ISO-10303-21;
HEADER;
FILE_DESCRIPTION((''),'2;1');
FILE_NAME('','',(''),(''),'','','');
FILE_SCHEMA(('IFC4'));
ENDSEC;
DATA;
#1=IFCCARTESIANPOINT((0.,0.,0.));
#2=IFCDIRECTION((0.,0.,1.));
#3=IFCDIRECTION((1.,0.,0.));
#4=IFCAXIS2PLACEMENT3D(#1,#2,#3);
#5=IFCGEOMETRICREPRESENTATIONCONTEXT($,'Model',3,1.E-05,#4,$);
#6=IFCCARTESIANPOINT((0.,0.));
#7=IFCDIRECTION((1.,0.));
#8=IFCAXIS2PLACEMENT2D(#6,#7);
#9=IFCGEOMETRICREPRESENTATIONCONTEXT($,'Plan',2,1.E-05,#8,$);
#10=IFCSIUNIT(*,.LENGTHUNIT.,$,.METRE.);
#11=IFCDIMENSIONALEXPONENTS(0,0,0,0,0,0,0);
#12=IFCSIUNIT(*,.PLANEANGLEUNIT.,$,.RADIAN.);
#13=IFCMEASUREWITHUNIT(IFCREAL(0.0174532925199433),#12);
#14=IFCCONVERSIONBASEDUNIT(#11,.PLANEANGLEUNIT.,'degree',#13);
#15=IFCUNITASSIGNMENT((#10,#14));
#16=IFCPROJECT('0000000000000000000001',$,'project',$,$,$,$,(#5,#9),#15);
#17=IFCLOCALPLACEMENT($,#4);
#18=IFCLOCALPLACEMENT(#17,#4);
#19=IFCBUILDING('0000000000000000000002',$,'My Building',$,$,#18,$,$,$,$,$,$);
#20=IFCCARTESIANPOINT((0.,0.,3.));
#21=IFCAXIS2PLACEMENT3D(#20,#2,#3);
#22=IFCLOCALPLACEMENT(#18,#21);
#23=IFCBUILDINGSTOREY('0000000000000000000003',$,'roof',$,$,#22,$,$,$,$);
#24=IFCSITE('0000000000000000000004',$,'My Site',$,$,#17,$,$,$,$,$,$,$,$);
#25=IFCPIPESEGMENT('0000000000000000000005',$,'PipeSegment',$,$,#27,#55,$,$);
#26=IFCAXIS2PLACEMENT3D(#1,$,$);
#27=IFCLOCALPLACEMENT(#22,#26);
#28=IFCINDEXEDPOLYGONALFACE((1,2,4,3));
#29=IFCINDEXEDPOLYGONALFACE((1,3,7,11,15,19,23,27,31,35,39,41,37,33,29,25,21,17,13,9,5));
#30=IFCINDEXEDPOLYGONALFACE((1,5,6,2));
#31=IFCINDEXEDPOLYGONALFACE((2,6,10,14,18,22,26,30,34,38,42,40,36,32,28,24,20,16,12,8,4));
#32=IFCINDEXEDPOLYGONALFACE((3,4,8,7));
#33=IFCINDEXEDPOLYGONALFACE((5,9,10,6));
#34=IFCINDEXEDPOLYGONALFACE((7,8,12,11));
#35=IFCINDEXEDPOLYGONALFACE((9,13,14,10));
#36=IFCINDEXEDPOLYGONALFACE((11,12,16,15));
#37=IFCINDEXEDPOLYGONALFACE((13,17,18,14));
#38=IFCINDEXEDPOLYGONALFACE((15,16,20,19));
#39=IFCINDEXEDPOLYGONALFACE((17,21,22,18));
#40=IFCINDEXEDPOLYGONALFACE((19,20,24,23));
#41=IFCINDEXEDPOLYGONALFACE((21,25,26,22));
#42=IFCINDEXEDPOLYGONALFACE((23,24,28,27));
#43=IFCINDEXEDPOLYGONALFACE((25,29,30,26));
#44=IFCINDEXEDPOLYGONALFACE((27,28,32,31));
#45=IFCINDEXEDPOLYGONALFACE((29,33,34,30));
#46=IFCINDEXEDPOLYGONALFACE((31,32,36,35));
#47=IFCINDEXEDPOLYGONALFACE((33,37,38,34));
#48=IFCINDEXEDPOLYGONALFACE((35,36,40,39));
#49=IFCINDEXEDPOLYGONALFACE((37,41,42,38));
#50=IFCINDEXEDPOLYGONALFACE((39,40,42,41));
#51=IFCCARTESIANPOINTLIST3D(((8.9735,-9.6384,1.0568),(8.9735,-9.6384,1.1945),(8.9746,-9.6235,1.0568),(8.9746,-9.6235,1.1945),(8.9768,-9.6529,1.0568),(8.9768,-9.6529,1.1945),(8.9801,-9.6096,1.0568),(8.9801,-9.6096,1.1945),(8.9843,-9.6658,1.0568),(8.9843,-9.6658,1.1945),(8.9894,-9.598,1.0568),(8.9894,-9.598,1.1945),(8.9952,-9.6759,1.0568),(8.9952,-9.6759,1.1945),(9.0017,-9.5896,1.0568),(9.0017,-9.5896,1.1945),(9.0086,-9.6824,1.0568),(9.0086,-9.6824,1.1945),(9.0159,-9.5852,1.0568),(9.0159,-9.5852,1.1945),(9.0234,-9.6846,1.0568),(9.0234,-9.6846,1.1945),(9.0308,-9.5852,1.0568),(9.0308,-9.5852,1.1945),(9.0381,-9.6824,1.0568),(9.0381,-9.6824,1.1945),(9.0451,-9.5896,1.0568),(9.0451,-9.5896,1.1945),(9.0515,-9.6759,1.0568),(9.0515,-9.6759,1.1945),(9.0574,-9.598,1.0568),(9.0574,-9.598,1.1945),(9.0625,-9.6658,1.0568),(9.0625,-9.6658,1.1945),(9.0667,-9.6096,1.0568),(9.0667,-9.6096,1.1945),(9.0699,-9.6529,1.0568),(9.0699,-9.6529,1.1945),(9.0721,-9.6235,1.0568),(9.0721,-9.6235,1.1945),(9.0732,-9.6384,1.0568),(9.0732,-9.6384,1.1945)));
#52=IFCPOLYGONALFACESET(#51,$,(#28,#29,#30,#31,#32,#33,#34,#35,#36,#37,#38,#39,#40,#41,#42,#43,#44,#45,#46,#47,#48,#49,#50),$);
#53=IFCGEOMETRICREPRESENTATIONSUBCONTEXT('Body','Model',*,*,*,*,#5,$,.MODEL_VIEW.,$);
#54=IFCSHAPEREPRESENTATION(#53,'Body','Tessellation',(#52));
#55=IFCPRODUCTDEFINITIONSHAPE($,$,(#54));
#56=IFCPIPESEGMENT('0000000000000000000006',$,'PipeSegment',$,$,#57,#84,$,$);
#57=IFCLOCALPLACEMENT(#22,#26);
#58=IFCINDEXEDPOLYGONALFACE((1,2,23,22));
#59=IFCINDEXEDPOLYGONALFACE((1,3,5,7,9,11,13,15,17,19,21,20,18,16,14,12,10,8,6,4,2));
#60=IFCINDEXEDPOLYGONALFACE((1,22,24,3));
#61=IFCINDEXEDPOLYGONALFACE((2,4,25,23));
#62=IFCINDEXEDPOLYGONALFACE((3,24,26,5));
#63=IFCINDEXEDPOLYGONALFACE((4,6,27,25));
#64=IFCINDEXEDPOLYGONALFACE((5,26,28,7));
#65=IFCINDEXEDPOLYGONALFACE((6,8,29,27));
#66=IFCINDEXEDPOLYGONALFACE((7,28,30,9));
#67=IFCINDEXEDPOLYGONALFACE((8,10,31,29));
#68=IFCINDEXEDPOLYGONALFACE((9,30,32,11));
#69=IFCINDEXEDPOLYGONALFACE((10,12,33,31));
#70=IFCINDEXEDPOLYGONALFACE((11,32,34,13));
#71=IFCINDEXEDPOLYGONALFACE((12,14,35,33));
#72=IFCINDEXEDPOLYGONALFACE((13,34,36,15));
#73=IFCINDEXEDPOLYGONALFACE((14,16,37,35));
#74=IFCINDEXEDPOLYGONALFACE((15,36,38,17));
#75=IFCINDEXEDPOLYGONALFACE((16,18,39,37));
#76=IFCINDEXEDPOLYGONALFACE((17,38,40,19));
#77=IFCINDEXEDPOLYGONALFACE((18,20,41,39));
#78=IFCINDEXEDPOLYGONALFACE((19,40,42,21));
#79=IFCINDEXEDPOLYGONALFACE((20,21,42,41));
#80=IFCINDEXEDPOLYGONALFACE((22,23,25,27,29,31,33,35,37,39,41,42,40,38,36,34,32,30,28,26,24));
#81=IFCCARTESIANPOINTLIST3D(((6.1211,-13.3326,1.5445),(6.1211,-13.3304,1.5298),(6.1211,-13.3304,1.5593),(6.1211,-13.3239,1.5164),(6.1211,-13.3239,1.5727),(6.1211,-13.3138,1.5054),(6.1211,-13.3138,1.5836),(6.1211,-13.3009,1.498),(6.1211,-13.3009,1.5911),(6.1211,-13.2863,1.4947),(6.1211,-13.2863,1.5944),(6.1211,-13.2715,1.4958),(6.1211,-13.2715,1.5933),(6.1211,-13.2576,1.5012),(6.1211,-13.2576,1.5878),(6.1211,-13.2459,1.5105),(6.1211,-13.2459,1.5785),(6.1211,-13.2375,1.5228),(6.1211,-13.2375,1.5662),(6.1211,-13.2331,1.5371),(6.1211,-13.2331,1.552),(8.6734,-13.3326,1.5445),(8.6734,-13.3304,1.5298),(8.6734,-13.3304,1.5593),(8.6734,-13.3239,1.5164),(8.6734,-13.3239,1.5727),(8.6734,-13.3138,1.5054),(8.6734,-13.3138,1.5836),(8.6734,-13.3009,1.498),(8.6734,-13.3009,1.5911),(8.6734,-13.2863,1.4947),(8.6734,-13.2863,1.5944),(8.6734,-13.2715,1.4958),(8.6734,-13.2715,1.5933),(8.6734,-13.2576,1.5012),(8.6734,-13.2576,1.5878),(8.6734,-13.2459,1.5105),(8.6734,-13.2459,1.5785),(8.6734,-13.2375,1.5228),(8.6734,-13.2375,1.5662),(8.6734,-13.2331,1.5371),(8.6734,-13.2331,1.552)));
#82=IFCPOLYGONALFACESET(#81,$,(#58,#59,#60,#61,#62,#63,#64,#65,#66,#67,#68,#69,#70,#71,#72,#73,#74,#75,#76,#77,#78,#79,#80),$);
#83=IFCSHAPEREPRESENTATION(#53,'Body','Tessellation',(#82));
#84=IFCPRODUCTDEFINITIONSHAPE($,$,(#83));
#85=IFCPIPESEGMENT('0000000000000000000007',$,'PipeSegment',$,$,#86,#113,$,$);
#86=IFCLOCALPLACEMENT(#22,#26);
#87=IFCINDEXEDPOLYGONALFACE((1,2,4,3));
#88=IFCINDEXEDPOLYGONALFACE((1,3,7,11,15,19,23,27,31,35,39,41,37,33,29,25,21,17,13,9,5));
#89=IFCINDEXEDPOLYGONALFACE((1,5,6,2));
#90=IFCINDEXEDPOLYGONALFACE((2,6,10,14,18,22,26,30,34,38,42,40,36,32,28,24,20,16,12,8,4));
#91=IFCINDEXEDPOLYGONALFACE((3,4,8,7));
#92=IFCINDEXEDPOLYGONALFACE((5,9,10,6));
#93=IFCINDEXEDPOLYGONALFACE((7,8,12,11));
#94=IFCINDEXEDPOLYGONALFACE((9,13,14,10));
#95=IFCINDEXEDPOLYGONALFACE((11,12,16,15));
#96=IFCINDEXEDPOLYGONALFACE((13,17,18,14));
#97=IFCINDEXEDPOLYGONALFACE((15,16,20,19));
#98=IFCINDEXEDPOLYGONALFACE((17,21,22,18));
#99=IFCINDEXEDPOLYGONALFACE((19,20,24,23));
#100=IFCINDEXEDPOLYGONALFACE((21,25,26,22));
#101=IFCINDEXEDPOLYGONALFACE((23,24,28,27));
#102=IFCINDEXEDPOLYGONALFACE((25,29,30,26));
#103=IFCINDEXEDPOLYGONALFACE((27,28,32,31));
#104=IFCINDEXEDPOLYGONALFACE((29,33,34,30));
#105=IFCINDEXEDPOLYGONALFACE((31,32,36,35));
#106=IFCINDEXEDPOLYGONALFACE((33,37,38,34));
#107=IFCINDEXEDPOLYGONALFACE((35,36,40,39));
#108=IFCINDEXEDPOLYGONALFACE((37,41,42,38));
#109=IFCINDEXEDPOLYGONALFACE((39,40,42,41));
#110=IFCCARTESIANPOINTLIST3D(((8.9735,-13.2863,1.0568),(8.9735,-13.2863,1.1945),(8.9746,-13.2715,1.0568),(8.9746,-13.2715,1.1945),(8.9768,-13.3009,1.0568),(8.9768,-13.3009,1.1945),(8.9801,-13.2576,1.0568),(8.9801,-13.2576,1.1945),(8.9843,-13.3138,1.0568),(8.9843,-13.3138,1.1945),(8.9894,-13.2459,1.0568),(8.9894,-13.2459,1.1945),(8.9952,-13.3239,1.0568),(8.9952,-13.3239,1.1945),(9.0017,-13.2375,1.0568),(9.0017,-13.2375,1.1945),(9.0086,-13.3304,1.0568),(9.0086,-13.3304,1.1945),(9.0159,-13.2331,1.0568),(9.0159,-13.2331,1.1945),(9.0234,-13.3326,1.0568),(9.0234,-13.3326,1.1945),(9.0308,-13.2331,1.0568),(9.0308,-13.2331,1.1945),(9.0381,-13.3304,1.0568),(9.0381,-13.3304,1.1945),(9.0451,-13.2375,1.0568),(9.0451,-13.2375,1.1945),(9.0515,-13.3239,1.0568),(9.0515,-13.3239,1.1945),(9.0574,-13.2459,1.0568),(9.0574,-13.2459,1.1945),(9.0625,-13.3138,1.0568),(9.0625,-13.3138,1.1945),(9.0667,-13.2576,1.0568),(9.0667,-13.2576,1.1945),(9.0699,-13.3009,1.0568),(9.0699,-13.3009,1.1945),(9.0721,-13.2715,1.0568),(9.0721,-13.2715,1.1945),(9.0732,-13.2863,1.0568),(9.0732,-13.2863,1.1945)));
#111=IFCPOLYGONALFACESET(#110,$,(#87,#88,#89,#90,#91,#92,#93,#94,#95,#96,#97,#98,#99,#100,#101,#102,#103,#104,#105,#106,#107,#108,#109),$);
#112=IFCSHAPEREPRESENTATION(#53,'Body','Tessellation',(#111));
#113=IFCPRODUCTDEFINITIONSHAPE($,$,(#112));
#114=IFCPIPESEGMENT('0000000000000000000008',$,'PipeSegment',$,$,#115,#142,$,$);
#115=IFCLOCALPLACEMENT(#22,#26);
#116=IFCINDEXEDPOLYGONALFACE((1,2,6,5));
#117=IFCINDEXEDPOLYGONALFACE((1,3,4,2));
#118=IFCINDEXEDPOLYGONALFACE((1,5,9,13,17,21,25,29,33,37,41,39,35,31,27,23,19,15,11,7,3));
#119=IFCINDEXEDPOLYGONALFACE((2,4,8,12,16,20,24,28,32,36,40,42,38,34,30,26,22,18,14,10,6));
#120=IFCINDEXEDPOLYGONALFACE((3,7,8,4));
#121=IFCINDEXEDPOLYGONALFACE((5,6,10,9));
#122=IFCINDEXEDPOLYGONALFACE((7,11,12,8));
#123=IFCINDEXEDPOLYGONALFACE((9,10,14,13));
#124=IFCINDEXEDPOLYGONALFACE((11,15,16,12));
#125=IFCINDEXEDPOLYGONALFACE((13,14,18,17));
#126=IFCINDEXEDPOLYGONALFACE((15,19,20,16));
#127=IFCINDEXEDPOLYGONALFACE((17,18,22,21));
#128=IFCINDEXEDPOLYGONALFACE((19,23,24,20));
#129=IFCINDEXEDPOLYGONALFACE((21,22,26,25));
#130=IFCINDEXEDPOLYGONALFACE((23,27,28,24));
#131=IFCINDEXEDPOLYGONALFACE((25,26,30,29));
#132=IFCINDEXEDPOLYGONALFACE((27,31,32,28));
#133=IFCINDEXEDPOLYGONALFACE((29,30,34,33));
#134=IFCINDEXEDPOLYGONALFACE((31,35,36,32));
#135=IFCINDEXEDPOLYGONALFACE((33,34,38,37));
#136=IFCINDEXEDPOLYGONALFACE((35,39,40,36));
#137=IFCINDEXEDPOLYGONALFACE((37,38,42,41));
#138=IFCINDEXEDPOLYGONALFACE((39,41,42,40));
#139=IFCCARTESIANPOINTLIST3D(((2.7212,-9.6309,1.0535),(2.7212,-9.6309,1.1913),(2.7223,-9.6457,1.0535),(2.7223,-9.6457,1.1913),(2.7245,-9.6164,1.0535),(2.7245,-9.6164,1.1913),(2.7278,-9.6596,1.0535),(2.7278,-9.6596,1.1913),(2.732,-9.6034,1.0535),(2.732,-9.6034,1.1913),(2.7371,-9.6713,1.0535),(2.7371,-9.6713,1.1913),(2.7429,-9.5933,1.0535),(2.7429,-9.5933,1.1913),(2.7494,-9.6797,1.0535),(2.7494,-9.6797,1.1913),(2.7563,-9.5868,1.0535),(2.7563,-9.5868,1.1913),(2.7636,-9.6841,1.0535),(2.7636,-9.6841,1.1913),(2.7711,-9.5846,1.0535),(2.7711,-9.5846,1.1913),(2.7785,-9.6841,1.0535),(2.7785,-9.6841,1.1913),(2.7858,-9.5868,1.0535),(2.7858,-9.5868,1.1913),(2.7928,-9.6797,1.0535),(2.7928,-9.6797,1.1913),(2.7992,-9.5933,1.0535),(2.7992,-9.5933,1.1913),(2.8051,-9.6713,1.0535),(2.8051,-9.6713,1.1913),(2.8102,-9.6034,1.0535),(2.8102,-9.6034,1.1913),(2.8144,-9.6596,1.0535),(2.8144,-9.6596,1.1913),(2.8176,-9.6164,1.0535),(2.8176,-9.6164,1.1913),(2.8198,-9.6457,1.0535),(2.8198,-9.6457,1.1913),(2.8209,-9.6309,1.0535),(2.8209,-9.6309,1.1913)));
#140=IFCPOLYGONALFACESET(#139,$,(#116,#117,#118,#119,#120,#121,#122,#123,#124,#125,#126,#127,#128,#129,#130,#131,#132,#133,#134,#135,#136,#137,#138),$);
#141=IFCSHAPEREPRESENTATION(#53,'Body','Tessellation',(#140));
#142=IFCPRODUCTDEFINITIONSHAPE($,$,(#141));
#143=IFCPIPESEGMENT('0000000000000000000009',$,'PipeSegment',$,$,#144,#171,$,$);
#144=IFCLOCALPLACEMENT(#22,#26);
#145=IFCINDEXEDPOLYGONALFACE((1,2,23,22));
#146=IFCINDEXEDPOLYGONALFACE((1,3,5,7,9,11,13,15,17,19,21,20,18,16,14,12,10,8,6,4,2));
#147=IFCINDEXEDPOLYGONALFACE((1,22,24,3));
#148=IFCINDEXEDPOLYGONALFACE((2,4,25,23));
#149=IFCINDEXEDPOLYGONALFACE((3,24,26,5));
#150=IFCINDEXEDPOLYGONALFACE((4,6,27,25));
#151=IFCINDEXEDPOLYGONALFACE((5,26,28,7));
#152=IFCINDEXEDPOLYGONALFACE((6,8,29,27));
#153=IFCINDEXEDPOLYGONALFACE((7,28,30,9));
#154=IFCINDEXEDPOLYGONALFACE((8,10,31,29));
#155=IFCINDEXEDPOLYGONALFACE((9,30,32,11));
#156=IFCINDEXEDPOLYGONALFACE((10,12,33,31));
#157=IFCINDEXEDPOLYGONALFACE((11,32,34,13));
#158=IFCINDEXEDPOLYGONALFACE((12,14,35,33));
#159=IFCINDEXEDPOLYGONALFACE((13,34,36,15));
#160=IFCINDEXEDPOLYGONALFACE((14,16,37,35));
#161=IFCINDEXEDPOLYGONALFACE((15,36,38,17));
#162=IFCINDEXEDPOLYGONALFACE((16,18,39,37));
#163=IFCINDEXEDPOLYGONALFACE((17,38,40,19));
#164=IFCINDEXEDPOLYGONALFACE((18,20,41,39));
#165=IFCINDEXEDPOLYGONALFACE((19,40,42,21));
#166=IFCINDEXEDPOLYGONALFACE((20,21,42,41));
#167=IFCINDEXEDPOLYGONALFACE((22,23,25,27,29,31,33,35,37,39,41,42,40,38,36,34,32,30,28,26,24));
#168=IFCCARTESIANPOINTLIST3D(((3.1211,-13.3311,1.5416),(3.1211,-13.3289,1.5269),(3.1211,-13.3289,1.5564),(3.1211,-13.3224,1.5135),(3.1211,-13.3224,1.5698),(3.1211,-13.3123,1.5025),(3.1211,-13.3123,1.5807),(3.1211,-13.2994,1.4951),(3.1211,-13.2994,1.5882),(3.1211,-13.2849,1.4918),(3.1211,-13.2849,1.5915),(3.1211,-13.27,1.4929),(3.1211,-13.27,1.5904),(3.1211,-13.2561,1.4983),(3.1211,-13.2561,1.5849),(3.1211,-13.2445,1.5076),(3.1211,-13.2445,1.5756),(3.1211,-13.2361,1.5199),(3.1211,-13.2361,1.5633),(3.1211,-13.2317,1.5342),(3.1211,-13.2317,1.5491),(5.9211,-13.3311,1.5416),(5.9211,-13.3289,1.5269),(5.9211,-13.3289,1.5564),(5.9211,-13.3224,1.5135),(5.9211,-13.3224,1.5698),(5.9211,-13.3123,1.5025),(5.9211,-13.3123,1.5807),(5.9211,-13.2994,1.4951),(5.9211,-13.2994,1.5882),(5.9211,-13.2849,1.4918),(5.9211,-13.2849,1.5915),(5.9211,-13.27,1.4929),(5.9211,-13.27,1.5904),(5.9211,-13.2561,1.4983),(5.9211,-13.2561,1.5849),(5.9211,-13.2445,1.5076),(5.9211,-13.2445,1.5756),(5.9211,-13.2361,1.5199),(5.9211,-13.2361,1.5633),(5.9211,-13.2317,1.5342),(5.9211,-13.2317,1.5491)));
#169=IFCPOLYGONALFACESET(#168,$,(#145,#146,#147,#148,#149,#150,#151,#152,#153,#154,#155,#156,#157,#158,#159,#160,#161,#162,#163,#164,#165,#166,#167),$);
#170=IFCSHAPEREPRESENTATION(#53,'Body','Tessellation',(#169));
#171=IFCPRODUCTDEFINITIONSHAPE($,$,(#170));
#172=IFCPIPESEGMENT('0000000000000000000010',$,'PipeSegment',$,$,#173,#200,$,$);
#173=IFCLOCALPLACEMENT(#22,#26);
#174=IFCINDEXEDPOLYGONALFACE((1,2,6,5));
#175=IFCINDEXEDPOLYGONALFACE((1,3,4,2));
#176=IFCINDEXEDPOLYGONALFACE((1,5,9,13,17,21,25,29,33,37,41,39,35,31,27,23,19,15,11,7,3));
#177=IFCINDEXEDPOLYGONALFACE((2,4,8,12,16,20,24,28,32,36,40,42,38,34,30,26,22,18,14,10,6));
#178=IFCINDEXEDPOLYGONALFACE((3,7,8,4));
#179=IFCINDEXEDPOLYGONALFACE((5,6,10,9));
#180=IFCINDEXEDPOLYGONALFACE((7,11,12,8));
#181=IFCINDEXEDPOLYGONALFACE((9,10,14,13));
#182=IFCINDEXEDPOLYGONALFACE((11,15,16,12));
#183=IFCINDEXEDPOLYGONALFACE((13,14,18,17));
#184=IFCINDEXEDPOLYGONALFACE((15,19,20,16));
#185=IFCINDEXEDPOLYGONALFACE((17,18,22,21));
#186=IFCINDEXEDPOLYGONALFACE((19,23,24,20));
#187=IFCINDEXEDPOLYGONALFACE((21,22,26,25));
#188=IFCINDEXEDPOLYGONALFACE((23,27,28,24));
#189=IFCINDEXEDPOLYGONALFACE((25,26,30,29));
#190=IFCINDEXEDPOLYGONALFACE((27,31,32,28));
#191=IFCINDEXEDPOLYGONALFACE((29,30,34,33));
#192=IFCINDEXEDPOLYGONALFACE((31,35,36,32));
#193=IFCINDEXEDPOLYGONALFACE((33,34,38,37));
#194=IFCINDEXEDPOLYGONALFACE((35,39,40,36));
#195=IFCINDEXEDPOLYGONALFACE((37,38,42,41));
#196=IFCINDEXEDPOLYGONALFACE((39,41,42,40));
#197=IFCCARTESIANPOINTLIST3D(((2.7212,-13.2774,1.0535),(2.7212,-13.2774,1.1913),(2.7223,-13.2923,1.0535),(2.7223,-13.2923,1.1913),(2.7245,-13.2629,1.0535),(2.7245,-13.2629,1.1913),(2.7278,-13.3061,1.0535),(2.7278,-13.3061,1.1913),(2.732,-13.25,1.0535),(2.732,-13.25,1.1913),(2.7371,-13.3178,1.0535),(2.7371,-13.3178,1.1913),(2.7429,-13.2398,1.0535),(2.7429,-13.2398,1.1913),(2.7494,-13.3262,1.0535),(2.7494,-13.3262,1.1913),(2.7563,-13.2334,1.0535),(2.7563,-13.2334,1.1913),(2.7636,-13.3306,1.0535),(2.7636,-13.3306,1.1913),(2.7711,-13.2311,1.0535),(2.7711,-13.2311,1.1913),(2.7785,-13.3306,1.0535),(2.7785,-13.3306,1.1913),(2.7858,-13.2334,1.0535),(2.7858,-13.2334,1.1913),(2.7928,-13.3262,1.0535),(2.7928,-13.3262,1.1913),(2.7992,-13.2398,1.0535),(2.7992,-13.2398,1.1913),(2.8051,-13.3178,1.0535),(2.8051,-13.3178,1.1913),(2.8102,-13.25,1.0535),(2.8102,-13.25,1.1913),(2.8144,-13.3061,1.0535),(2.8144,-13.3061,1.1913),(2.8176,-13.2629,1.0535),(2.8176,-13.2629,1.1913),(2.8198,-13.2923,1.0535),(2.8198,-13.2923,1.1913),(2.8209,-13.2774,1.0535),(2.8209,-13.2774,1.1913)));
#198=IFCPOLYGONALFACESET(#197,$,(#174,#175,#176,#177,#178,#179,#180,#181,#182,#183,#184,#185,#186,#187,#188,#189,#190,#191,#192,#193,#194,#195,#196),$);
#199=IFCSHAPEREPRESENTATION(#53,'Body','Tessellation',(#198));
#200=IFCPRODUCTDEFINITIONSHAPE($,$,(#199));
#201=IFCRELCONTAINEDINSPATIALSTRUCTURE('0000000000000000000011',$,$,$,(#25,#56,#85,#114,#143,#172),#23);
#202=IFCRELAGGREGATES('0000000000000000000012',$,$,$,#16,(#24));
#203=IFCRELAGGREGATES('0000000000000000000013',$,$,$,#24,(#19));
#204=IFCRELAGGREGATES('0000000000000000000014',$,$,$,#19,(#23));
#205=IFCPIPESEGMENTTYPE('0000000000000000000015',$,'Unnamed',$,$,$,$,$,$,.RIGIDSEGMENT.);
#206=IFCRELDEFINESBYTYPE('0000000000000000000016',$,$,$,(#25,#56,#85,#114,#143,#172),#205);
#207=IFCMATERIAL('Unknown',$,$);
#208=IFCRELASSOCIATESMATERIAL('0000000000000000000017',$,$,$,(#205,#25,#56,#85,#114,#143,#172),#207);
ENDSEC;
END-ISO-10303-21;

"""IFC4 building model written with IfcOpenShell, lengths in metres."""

from ifc_helpers import new_model, entity, si_unit, converted_unit, frame, origin_with_axes, origin_2d_with_axis, place, context, subcontext, project, spatial, circle, extrude, material, material_profile, profile_set, profile_usage, type_object, element, save


model = new_model("IFC4")

# Units and contexts
model_context = context("Model", 3, precision=1e-05, world=origin_with_axes())
plan_context = context("Plan", 2, precision=1e-05, world=origin_2d_with_axis())
body_context_1 = subcontext(model_context, "Body", "Model", "MODEL_VIEW")
ifc_project = project(units=[si_unit("LENGTHUNIT", "METRE"), converted_unit("PLANEANGLEUNIT", "degree", entity("IfcReal", 0.0174532925199433), si_unit("PLANEANGLEUNIT", "RADIAN"), dimensions=[0, 0, 0, 0, 0, 0, 0])], contexts=[model_context, plan_context])

# Site, building, storey
site_placement = place(None, origin_with_axes())
site = spatial("IfcSite", under=ifc_project, at=site_placement, Name="My Site")
building_placement = place(site_placement, origin_with_axes())
building = spatial("IfcBuilding", under=site, at=building_placement, Name="My Building")
storey_placement = place(building_placement, frame((0.0, 0.0, 3.0), z_axis=(0.0, 0.0, 1.0), x_axis=(1.0, 0.0, 0.0)))
storey = spatial("IfcBuildingStorey", under=building, at=storey_placement, Name="roof")

# Shared definitions
ifc_material = material(Name="Unknown")

# Pipe segments
ifc_material_profile_1 = material_profile(ifc_material, circle(Radius=0.05))
ifc_profile_set_1 = profile_set([ifc_material_profile_1])
ifc_profile_usage_1 = profile_usage(ifc_profile_set_1, cardinal=5)
pipe_segment_type = type_object("IfcPipeSegmentType", Name="Unnamed", PredefinedType="RIGIDSEGMENT", material=ifc_profile_set_1)
pipe_segment_1_placement = place(storey_placement, frame((9.0234, -9.6346, 1.0568), z_axis=(0.000001, -0.000001, 1.0), x_axis=(0.0, -1.0, -0.000001)))
element("IfcPipeSegment", 1, at=pipe_segment_1_placement, inside=storey, type_object=pipe_segment_type, material=ifc_profile_usage_1, Name="PipeSegment", context=body_context_1, shape_type="SweptSolid", body=[
    extrude(circle(Radius=0.05), origin_with_axes(), (0.0, 0.0, 1.0), 0.1377),
])
ifc_profile_usage_2 = profile_usage(ifc_profile_set_1, cardinal=5)
pipe_segment_2_placement = place(storey_placement, frame((6.1211, -13.2826, 1.5445), z_axis=(1.0, 0.0, 0.0), x_axis=(0.0, -1.0, 0.0)))
element("IfcPipeSegment", 2, at=pipe_segment_2_placement, inside=storey, type_object=pipe_segment_type, material=ifc_profile_usage_2, Name="PipeSegment", context=body_context_1, shape_type="SweptSolid", body=[
    extrude(circle(Radius=0.05), origin_with_axes(), (0.0, 0.0, 1.0), 2.5523),
])
ifc_profile_usage_3 = profile_usage(ifc_profile_set_1, cardinal=5)
pipe_segment_3_placement = place(storey_placement, frame((9.0234, -13.2826, 1.0568), z_axis=(0.000001, -0.000001, 1.0), x_axis=(0.0, -1.0, -0.000001)))
element("IfcPipeSegment", 3, at=pipe_segment_3_placement, inside=storey, type_object=pipe_segment_type, material=ifc_profile_usage_3, Name="PipeSegment", context=body_context_1, shape_type="SweptSolid", body=[
    extrude(circle(Radius=0.05), origin_with_axes(), (0.0, 0.0, 1.0), 0.1377),
])
ifc_profile_usage_4 = profile_usage(ifc_profile_set_1, cardinal=5)
pipe_segment_4_placement = place(storey_placement, frame((2.7711, -9.6346, 1.0535), z_axis=(-0.000001, 0.000001, 1.0), x_axis=(0.0, 1.0, -0.000001)))
element("IfcPipeSegment", 4, at=pipe_segment_4_placement, inside=storey, type_object=pipe_segment_type, material=ifc_profile_usage_4, Name="PipeSegment", context=body_context_1, shape_type="SweptSolid", body=[
    extrude(circle(Radius=0.05), origin_with_axes(), (0.0, 0.0, 1.0), 0.1377),
])
ifc_profile_usage_5 = profile_usage(ifc_profile_set_1, cardinal=5)
pipe_segment_5_placement = place(storey_placement, frame((5.9211, -13.2811, 1.5416), z_axis=(-1.0, 0.0, 0.0), x_axis=(0.0, -1.0, 0.0)))
element("IfcPipeSegment", 5, at=pipe_segment_5_placement, inside=storey, type_object=pipe_segment_type, material=ifc_profile_usage_5, Name="PipeSegment", context=body_context_1, shape_type="SweptSolid", body=[
    extrude(circle(Radius=0.05), origin_with_axes(), (0.0, 0.0, 1.0), 2.8),
])
ifc_profile_usage_6 = profile_usage(ifc_profile_set_1, cardinal=5)
pipe_segment_6_placement = place(storey_placement, frame((2.7711, -13.2811, 1.0535), z_axis=(-0.000001, 0.000001, 1.0), x_axis=(0.0, 1.0, -0.000001)))
element("IfcPipeSegment", 6, at=pipe_segment_6_placement, inside=storey, type_object=pipe_segment_type, material=ifc_profile_usage_6, Name="PipeSegment", context=body_context_1, shape_type="SweptSolid", body=[
    extrude(circle(Radius=0.05), origin_with_axes(), (0.0, 0.0, 1.0), 0.1377),
])

save(model, "model.ifc")
